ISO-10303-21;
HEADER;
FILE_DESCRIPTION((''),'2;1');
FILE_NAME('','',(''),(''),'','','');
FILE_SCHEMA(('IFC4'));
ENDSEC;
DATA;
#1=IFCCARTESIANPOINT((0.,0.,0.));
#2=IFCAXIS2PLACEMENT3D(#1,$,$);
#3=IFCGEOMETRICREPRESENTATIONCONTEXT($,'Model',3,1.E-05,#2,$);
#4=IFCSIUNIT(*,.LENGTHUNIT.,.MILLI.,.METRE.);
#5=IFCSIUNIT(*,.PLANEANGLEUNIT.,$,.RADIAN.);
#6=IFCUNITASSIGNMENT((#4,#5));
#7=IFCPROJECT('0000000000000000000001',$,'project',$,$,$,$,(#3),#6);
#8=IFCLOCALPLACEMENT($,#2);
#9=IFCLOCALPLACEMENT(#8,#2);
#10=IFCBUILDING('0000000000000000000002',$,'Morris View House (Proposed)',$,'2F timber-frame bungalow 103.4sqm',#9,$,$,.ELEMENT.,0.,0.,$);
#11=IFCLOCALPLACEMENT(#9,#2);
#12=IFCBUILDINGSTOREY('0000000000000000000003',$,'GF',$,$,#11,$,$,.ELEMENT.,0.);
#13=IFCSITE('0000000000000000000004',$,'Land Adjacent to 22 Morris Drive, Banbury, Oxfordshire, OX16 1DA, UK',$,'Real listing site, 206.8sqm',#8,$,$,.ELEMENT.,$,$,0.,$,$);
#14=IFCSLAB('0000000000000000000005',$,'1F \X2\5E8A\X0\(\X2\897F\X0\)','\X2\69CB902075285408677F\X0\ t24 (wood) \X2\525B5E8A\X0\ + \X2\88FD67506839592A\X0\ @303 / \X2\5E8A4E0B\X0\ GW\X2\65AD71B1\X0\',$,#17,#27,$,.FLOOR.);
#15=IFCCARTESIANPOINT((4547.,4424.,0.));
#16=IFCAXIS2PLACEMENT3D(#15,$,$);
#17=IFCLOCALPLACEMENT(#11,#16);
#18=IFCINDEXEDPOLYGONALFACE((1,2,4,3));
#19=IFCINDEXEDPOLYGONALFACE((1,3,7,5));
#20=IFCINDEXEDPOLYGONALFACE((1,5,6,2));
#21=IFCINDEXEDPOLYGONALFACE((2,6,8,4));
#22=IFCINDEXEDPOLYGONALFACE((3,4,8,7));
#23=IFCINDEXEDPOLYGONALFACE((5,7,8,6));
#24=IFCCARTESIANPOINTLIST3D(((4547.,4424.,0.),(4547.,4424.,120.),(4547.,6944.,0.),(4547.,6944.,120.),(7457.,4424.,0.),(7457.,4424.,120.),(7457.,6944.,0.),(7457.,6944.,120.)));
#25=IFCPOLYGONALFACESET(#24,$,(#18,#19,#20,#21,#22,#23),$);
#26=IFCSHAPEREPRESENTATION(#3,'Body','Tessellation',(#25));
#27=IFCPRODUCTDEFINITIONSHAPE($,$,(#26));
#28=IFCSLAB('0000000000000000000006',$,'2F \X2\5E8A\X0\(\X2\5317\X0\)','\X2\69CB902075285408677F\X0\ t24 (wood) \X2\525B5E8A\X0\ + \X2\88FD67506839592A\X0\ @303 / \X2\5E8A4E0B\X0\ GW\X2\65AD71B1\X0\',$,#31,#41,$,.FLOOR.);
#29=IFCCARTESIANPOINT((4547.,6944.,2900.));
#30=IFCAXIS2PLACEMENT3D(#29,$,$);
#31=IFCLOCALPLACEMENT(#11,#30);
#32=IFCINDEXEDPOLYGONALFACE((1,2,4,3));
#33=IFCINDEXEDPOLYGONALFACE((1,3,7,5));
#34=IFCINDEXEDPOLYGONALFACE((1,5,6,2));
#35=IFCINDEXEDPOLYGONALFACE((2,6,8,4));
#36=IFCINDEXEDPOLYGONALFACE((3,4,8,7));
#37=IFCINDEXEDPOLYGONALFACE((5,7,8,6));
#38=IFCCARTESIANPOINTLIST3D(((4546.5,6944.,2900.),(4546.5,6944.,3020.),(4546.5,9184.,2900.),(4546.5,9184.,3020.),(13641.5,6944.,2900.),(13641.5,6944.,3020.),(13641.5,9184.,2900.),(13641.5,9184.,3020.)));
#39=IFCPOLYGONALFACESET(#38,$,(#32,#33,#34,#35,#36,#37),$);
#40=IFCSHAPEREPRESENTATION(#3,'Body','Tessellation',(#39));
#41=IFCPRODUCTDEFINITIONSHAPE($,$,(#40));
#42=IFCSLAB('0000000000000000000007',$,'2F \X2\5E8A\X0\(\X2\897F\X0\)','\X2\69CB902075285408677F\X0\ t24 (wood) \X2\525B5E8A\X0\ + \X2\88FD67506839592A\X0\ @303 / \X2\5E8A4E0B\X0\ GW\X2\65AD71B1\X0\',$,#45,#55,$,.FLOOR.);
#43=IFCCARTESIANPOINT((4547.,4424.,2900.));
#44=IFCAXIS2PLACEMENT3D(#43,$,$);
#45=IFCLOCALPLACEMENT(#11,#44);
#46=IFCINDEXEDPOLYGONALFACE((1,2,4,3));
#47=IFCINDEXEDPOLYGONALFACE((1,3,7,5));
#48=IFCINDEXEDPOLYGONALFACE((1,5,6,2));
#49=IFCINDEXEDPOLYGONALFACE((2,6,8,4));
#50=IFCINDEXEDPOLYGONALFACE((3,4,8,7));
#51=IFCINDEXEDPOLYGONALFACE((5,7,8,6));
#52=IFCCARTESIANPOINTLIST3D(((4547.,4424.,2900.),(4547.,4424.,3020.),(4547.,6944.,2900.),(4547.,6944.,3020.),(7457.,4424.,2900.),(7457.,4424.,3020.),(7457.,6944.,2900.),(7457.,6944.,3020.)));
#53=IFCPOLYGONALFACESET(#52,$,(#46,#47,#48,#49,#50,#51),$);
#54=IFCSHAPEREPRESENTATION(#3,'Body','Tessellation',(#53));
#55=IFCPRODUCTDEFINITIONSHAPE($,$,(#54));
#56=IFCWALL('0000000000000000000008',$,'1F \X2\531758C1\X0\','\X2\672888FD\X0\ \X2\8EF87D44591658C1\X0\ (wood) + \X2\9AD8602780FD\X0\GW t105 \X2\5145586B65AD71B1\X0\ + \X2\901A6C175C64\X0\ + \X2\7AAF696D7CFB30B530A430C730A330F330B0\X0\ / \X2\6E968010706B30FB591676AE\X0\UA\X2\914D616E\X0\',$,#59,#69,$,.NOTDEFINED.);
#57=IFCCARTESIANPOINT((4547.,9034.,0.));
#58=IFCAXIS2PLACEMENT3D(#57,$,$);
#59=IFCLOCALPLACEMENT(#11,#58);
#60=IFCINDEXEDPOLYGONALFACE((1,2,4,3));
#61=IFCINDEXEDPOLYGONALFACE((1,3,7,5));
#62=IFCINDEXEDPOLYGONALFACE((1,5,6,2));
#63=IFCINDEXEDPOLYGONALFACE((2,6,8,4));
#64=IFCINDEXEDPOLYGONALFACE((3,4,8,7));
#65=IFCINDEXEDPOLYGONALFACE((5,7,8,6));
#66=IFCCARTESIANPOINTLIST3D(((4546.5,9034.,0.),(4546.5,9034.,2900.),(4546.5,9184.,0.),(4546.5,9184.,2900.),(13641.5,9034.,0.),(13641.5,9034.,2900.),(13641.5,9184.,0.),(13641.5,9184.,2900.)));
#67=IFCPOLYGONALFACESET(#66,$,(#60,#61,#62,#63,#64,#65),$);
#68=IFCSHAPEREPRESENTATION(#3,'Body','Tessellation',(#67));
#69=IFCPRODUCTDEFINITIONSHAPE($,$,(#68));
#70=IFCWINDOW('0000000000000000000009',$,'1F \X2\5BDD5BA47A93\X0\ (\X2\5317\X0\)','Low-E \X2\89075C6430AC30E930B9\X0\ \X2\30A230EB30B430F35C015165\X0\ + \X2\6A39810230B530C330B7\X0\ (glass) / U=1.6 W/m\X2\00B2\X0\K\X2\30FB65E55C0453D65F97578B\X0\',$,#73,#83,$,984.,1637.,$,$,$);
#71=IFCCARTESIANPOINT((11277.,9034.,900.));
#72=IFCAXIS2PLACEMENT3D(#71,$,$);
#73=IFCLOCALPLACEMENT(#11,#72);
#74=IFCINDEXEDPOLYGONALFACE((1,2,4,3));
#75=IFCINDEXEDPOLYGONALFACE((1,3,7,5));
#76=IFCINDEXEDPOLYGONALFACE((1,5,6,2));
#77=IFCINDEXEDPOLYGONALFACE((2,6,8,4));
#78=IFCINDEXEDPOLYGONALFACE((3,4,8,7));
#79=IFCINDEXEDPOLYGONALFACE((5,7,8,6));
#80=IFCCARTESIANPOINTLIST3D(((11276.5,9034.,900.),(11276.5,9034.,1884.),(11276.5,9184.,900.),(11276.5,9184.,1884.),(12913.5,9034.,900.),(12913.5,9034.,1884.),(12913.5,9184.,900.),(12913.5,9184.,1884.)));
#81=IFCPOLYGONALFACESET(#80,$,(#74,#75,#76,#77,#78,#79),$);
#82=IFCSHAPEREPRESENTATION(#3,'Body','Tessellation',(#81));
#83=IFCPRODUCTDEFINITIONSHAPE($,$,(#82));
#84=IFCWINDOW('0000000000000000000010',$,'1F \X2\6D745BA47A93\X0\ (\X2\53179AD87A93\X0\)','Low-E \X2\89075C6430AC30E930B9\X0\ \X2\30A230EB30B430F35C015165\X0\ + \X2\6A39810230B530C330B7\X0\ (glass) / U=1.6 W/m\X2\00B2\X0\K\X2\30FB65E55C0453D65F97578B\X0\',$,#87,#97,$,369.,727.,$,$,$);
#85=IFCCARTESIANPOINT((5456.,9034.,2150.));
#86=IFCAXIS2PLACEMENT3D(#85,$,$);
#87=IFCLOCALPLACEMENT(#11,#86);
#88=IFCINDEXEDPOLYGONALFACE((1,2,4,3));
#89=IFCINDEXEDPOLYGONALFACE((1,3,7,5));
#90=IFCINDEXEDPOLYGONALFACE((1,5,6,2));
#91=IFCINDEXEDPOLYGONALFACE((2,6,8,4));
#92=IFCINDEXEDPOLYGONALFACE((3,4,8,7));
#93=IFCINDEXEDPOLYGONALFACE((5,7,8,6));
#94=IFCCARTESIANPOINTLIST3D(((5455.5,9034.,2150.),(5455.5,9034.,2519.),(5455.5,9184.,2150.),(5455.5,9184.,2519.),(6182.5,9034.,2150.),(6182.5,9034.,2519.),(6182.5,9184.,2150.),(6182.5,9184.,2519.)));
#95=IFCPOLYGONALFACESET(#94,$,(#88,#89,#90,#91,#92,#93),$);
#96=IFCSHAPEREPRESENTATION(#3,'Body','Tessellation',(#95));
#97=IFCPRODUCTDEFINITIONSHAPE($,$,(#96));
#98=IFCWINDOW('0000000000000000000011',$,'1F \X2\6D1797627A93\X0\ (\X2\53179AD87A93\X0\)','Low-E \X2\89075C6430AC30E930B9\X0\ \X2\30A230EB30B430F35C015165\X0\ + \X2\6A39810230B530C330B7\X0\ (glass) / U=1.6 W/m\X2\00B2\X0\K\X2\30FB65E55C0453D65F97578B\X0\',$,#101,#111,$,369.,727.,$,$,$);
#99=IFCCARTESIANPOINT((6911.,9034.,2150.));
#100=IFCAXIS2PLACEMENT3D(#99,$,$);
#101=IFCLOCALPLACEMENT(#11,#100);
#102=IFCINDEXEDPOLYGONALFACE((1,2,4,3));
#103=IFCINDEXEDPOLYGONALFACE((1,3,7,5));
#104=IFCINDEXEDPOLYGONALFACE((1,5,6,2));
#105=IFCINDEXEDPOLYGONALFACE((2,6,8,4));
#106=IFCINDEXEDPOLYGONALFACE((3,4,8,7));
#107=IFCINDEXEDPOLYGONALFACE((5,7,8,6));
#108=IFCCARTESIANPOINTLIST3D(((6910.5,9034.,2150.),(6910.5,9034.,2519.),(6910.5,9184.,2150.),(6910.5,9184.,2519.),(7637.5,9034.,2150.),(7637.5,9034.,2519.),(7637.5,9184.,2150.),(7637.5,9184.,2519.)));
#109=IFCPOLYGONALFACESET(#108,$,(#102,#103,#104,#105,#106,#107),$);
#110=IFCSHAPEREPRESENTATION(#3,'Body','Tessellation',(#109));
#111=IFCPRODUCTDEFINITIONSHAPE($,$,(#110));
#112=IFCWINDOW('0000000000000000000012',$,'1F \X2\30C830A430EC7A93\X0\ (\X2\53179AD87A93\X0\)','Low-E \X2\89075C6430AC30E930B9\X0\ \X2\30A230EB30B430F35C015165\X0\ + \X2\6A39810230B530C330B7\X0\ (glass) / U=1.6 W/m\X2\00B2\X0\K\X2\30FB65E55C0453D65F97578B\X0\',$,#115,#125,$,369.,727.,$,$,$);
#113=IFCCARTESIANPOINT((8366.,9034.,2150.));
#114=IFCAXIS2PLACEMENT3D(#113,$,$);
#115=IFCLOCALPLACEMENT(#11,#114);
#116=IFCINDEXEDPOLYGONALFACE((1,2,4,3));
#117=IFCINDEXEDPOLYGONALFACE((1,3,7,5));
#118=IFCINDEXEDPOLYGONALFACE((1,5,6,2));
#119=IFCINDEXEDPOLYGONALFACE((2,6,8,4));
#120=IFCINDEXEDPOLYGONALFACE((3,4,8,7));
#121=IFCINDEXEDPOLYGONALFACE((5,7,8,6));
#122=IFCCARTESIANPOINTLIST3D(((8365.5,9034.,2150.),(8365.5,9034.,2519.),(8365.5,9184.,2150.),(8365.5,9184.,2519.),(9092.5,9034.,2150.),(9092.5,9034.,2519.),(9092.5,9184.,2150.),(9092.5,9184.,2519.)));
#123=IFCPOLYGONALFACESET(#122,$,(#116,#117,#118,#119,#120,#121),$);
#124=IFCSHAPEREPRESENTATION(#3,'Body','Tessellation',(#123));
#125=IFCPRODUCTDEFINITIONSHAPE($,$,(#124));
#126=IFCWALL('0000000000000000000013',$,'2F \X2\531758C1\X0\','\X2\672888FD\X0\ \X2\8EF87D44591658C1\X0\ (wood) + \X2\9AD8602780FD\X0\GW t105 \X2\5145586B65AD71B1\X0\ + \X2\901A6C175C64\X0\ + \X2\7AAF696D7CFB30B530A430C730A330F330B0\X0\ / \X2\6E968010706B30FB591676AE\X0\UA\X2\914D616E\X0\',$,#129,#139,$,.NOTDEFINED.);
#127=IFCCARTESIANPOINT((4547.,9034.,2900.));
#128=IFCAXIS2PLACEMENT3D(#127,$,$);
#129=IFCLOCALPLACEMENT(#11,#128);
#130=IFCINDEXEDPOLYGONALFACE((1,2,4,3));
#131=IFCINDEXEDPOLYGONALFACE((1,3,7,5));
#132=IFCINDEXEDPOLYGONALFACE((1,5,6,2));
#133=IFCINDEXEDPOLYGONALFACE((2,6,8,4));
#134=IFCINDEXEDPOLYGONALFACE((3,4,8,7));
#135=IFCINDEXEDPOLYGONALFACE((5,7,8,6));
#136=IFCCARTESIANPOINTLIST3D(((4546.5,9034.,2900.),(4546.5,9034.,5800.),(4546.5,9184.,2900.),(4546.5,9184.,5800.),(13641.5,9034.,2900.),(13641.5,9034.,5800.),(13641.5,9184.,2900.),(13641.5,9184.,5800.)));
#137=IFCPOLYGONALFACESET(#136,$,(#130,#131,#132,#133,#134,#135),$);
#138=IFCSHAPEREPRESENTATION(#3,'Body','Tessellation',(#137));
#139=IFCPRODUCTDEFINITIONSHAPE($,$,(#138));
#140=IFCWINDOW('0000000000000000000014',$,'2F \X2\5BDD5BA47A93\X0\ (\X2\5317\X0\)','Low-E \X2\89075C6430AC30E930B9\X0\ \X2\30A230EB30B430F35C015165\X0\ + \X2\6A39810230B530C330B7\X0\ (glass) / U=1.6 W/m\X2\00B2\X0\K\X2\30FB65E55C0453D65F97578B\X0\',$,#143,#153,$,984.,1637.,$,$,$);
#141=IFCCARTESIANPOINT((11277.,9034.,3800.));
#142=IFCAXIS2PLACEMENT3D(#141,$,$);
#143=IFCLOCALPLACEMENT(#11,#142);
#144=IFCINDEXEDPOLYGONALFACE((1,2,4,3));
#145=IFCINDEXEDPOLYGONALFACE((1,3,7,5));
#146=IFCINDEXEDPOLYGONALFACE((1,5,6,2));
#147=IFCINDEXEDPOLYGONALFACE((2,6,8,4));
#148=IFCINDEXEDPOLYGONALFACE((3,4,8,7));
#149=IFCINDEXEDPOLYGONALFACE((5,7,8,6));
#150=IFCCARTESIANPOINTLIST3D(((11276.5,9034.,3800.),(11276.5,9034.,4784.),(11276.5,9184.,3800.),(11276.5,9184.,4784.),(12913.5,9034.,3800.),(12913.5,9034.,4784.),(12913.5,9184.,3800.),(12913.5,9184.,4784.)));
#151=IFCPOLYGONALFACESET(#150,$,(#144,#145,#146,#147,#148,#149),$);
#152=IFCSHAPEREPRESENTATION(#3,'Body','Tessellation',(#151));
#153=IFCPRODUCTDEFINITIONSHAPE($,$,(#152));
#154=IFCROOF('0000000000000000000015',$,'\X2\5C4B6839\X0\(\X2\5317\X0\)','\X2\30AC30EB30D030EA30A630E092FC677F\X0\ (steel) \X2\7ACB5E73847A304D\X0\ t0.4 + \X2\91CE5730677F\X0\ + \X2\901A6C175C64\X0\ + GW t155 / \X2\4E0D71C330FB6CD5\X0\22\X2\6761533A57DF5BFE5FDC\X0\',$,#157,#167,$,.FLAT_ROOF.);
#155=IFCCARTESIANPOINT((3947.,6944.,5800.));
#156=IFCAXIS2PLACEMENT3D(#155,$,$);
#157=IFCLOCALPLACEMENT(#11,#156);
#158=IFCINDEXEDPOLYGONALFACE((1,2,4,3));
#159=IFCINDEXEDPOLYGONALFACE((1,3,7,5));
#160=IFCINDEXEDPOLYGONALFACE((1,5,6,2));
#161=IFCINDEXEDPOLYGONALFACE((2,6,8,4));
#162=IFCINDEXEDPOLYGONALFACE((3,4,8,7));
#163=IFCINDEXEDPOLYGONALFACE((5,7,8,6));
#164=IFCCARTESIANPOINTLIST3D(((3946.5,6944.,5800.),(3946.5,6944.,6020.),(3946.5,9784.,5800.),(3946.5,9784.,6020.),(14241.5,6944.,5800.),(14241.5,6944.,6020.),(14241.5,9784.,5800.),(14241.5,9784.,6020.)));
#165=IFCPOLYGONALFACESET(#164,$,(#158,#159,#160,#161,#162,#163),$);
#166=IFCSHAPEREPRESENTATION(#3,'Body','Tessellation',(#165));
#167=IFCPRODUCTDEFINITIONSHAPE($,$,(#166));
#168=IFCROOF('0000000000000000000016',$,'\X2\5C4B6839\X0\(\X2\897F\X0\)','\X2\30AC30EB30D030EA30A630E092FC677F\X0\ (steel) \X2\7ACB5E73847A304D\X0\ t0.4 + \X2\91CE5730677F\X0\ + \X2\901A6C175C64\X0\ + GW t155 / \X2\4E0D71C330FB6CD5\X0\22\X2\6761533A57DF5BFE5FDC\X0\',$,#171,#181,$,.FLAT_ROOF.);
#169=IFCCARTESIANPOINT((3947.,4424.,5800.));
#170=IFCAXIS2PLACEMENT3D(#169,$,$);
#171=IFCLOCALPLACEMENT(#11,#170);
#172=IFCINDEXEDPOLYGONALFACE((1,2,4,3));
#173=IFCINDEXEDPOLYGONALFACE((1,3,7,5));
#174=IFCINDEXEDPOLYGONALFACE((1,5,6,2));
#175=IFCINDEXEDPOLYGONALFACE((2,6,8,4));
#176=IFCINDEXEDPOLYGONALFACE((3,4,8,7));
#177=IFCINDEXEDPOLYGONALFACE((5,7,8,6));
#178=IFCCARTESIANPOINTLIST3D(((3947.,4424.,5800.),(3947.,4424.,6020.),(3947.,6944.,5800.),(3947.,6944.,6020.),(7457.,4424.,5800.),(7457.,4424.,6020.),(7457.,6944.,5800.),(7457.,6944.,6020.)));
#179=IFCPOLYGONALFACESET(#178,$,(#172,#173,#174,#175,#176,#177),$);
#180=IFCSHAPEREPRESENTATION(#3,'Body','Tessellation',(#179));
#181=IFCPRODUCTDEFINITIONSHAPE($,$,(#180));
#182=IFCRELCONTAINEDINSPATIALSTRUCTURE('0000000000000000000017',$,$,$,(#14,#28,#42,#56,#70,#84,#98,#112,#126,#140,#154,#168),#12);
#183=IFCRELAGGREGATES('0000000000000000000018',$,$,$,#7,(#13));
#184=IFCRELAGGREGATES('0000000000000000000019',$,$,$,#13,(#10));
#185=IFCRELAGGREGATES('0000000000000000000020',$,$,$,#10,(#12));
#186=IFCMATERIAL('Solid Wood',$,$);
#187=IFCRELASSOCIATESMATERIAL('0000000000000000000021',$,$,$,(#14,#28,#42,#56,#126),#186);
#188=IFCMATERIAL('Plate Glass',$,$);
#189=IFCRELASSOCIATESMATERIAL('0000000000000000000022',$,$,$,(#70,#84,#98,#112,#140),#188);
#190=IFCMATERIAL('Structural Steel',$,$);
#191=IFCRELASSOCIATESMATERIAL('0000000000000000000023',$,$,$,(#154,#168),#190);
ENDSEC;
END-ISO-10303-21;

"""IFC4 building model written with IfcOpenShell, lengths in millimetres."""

from ifc_helpers import new_model, si_unit, frame, frame_2d, origin, place, context, project, spatial, rectangle, extrude, material, element, fill, save


model = new_model("IFC4")

# Units and contexts
model_context = context("Model", 3, precision=1e-05, world=origin())
ifc_project = project(units=[si_unit("LENGTHUNIT", "METRE", prefix="MILLI"), si_unit("PLANEANGLEUNIT", "RADIAN")], contexts=[model_context])

# Site, building, storey
site_placement = place(None, origin())
site = spatial("IfcSite", under=ifc_project, at=site_placement, Name="Land Adjacent to 22 Morris Drive, Banbury, Oxfordshire, OX16 1DA, UK", ObjectType="Real listing site, 206.8sqm", CompositionType="ELEMENT", RefElevation=0.0)
building_placement = place(site_placement, origin())
building = spatial("IfcBuilding", under=site, at=building_placement, Name="Morris View House (Proposed)", ObjectType="2F timber-frame bungalow 103.4sqm", CompositionType="ELEMENT", ElevationOfRefHeight=0.0, ElevationOfTerrain=0.0)
storey_placement = place(building_placement, origin())
storey = spatial("IfcBuildingStorey", under=building, at=storey_placement, Name="GF", CompositionType="ELEMENT", Elevation=0.0)

# Slabs
ifc_material_1 = material(Name="Solid Wood")
slab_1_placement = place(storey_placement, frame((4547.0, 4424.0, 0.0)))
element("IfcSlab", 1, at=slab_1_placement, inside=storey, material=ifc_material_1, Name="1F 床(西)", Description="構造用合板 t24 (wood) 剛床 + 製材根太 @303 / 床下 GW断熱", PredefinedType="FLOOR", context=model_context, shape_type="SweptSolid", body=[
    extrude(rectangle(XDim=2910.0, YDim=2520.0, at=frame_2d((1455.0, 1260.0))), frame((4547.0, 4424.0, 0.0)), (0.0, 0.0, 1.0), 120.0),
])
slab_2_placement = place(storey_placement, frame((4547.0, 6944.0, 2900.0)))
element("IfcSlab", 2, at=slab_2_placement, inside=storey, material=ifc_material_1, Name="2F 床(北)", Description="構造用合板 t24 (wood) 剛床 + 製材根太 @303 / 床下 GW断熱", PredefinedType="FLOOR", context=model_context, shape_type="SweptSolid", body=[
    extrude(rectangle(XDim=9095.0, YDim=2240.0, at=frame_2d((4547.0, 1120.0))), frame((4547.0, 6944.0, 2900.0)), (0.0, 0.0, 1.0), 120.0),
])
slab_3_placement = place(storey_placement, frame((4547.0, 4424.0, 2900.0)))
element("IfcSlab", 3, at=slab_3_placement, inside=storey, material=ifc_material_1, Name="2F 床(西)", Description="構造用合板 t24 (wood) 剛床 + 製材根太 @303 / 床下 GW断熱", PredefinedType="FLOOR", context=model_context, shape_type="SweptSolid", body=[
    extrude(rectangle(XDim=2910.0, YDim=2520.0, at=frame_2d((1455.0, 1260.0))), frame((4547.0, 4424.0, 2900.0)), (0.0, 0.0, 1.0), 120.0),
])

# Wall, openings, windows
wall_1_placement = place(storey_placement, frame((4547.0, 9034.0, 0.0)))
wall_1 = element("IfcWall", 4, at=wall_1_placement, inside=storey, material=ifc_material_1, Name="1F 北壁", Description="木製 軸組外壁 (wood) + 高性能GW t105 充填断熱 + 通気層 + 窯業系サイディング / 準耐火・外皮UA配慮", PredefinedType="NOTDEFINED", context=model_context, shape_type="SweptSolid", body=[
    extrude(rectangle(XDim=9095.0, YDim=150.0, at=frame_2d((4547.0, 75.0))), frame((4547.0, 9034.0, 0.0)), (0.0, 0.0, 1.0), 2900.0),
])
opening_1_placement = place(storey_placement, frame((11277.0, 9034.0, 900.0)))
opening_1 = element("IfcOpeningElement", 5, at=opening_1_placement, cuts=wall_1, PredefinedType="NOTDEFINED", context=model_context, shape_type="SweptSolid", body=[
    extrude(rectangle(XDim=1637.0, YDim=150.0, at=frame_2d((818.0, 75.0))), frame((11277.0, 9034.0, 900.0)), (0.0, 0.0, 1.0), 984.0),
])
opening_2_placement = place(storey_placement, frame((5456.0, 9034.0, 2150.0)))
opening_2 = element("IfcOpeningElement", 6, at=opening_2_placement, cuts=wall_1, PredefinedType="NOTDEFINED", context=model_context, shape_type="SweptSolid", body=[
    extrude(rectangle(XDim=727.0, YDim=150.0, at=frame_2d((363.0, 75.0))), frame((5456.0, 9034.0, 2150.0)), (0.0, 0.0, 1.0), 369.0),
])
opening_3_placement = place(storey_placement, frame((6911.0, 9034.0, 2150.0)))
opening_3 = element("IfcOpeningElement", 7, at=opening_3_placement, cuts=wall_1, PredefinedType="NOTDEFINED", context=model_context, shape_type="SweptSolid", body=[
    extrude(rectangle(XDim=727.0, YDim=150.0, at=frame_2d((363.0, 75.0))), frame((6911.0, 9034.0, 2150.0)), (0.0, 0.0, 1.0), 369.0),
])
opening_4_placement = place(storey_placement, frame((8366.0, 9034.0, 2150.0)))
opening_4 = element("IfcOpeningElement", 8, at=opening_4_placement, cuts=wall_1, PredefinedType="NOTDEFINED", context=model_context, shape_type="SweptSolid", body=[
    extrude(rectangle(XDim=727.0, YDim=150.0, at=frame_2d((363.0, 75.0))), frame((8366.0, 9034.0, 2150.0)), (0.0, 0.0, 1.0), 369.0),
])
ifc_material_2 = material(Name="Plate Glass")
window_1_placement = place(storey_placement, frame((11277.0, 9034.0, 900.0)))
window_1 = element("IfcWindow", 9, at=window_1_placement, inside=storey, material=ifc_material_2, Name="1F 寝室窓 (北)", Description="Low-E 複層ガラス アルゴン封入 + 樹脂サッシ (glass) / U=1.6 W/m²K・日射取得型", OverallHeight=984.0, OverallWidth=1637.0, context=model_context, shape_type="SweptSolid", body=[
    extrude(rectangle(XDim=1637.0, YDim=150.0, at=frame_2d((818.0, 75.0))), frame((11277.0, 9034.0, 900.0)), (0.0, 0.0, 1.0), 984.0),
])
fill(opening_1, window_1)
window_2_placement = place(storey_placement, frame((5456.0, 9034.0, 2150.0)))
window_2 = element("IfcWindow", 10, at=window_2_placement, inside=storey, material=ifc_material_2, Name="1F 浴室窓 (北高窓)", Description="Low-E 複層ガラス アルゴン封入 + 樹脂サッシ (glass) / U=1.6 W/m²K・日射取得型", OverallHeight=369.0, OverallWidth=727.0, context=model_context, shape_type="SweptSolid", body=[
    extrude(rectangle(XDim=727.0, YDim=150.0, at=frame_2d((363.0, 75.0))), frame((5456.0, 9034.0, 2150.0)), (0.0, 0.0, 1.0), 369.0),
])
fill(opening_2, window_2)
window_3_placement = place(storey_placement, frame((6911.0, 9034.0, 2150.0)))
window_3 = element("IfcWindow", 11, at=window_3_placement, inside=storey, material=ifc_material_2, Name="1F 洗面窓 (北高窓)", Description="Low-E 複層ガラス アルゴン封入 + 樹脂サッシ (glass) / U=1.6 W/m²K・日射取得型", OverallHeight=369.0, OverallWidth=727.0, context=model_context, shape_type="SweptSolid", body=[
    extrude(rectangle(XDim=727.0, YDim=150.0, at=frame_2d((363.0, 75.0))), frame((6911.0, 9034.0, 2150.0)), (0.0, 0.0, 1.0), 369.0),
])
fill(opening_3, window_3)
window_4_placement = place(storey_placement, frame((8366.0, 9034.0, 2150.0)))
window_4 = element("IfcWindow", 12, at=window_4_placement, inside=storey, material=ifc_material_2, Name="1F トイレ窓 (北高窓)", Description="Low-E 複層ガラス アルゴン封入 + 樹脂サッシ (glass) / U=1.6 W/m²K・日射取得型", OverallHeight=369.0, OverallWidth=727.0, context=model_context, shape_type="SweptSolid", body=[
    extrude(rectangle(XDim=727.0, YDim=150.0, at=frame_2d((363.0, 75.0))), frame((8366.0, 9034.0, 2150.0)), (0.0, 0.0, 1.0), 369.0),
])
fill(opening_4, window_4)

# Wall, opening, window
wall_2_placement = place(storey_placement, frame((4547.0, 9034.0, 2900.0)))
wall_2 = element("IfcWall", 13, at=wall_2_placement, inside=storey, material=ifc_material_1, Name="2F 北壁", Description="木製 軸組外壁 (wood) + 高性能GW t105 充填断熱 + 通気層 + 窯業系サイディング / 準耐火・外皮UA配慮", PredefinedType="NOTDEFINED", context=model_context, shape_type="SweptSolid", body=[
    extrude(rectangle(XDim=9095.0, YDim=150.0, at=frame_2d((4547.0, 75.0))), frame((4547.0, 9034.0, 2900.0)), (0.0, 0.0, 1.0), 2900.0),
])
opening_5_placement = place(storey_placement, frame((11277.0, 9034.0, 3800.0)))
opening_5 = element("IfcOpeningElement", 14, at=opening_5_placement, cuts=wall_2, PredefinedType="NOTDEFINED", context=model_context, shape_type="SweptSolid", body=[
    extrude(rectangle(XDim=1637.0, YDim=150.0, at=frame_2d((818.0, 75.0))), frame((11277.0, 9034.0, 3800.0)), (0.0, 0.0, 1.0), 984.0),
])
window_5_placement = place(storey_placement, frame((11277.0, 9034.0, 3800.0)))
window_5 = element("IfcWindow", 15, at=window_5_placement, inside=storey, material=ifc_material_2, Name="2F 寝室窓 (北)", Description="Low-E 複層ガラス アルゴン封入 + 樹脂サッシ (glass) / U=1.6 W/m²K・日射取得型", OverallHeight=984.0, OverallWidth=1637.0, context=model_context, shape_type="SweptSolid", body=[
    extrude(rectangle(XDim=1637.0, YDim=150.0, at=frame_2d((818.0, 75.0))), frame((11277.0, 9034.0, 3800.0)), (0.0, 0.0, 1.0), 984.0),
])
fill(opening_5, window_5)

# Roofs
ifc_material_3 = material(Name="Structural Steel")
for number, where, name in (
    (16, (3947.0, 6944.0, 5800.0), "屋根(北)"),
):
    element("IfcRoof", number, at=place(storey_placement, frame(where)), inside=storey, material=ifc_material_3, Name=name, Description="ガルバリウム鋼板 (steel) 立平葺き t0.4 + 野地板 + 通気層 + GW t155 / 不燃・法22条区域対応", PredefinedType="FLAT_ROOF", context=model_context, shape_type="SweptSolid", body=[
        extrude(rectangle(XDim=10295.0, YDim=2840.0, at=frame_2d((5147.0, 1420.0))), frame((3947.0, 6944.0, 5800.0)), (0.0, 0.0, 1.0), 220.0),
    ])
roof_placement = place(storey_placement, frame((3947.0, 4424.0, 5800.0)))
element("IfcRoof", 17, at=roof_placement, inside=storey, material=ifc_material_3, Name="屋根(西)", Description="ガルバリウム鋼板 (steel) 立平葺き t0.4 + 野地板 + 通気層 + GW t155 / 不燃・法22条区域対応", PredefinedType="FLAT_ROOF", context=model_context, shape_type="SweptSolid", body=[
    extrude(rectangle(XDim=3510.0, YDim=2520.0, at=frame_2d((1755.0, 1260.0))), frame((3947.0, 4424.0, 5800.0)), (0.0, 0.0, 1.0), 220.0),
])

save(model, "model.ifc")
